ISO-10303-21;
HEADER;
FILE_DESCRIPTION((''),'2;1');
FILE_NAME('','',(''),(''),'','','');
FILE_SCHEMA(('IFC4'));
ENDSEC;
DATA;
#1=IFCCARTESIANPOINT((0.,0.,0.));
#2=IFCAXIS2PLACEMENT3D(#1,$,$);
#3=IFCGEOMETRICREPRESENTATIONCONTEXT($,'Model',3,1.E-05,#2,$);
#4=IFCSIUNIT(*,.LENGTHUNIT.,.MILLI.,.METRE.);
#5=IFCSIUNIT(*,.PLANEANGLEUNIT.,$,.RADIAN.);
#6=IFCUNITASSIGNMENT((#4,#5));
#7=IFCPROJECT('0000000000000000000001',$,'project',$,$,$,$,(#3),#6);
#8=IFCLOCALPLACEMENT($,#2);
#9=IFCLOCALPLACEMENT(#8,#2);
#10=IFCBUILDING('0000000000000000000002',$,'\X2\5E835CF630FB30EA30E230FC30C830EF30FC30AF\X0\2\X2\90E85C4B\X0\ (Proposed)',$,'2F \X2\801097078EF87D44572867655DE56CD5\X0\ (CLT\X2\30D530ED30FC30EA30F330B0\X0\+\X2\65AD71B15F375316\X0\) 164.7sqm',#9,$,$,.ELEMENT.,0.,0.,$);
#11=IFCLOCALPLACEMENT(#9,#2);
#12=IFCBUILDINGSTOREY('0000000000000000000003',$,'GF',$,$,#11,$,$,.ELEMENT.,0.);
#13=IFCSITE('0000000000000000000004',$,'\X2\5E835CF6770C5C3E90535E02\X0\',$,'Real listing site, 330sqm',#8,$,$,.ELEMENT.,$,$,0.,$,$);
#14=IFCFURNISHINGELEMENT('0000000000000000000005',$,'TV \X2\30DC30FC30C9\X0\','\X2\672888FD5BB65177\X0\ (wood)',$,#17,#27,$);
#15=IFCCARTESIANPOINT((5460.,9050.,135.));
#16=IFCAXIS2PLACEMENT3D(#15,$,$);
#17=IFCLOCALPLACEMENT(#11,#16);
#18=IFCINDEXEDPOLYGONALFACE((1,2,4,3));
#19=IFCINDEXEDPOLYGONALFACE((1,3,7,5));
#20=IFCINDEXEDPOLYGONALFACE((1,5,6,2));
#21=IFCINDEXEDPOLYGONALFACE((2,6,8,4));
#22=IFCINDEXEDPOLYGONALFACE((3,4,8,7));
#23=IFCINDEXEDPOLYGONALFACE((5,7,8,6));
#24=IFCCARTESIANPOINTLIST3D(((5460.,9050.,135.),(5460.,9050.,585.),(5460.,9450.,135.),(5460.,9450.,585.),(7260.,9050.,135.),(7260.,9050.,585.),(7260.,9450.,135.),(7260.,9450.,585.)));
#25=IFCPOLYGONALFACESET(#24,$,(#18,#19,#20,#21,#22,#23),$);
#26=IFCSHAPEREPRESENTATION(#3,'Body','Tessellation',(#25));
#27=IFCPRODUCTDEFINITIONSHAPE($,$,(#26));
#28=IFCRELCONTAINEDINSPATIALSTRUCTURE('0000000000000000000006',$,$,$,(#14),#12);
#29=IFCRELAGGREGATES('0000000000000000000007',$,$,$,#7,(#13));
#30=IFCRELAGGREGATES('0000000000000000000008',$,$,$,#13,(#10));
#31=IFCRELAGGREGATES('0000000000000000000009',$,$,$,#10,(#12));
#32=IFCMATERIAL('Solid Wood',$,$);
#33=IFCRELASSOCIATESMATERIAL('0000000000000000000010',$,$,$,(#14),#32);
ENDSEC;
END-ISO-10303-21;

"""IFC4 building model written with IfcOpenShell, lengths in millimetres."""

from ifc_helpers import new_model, si_unit, frame, frame_2d, origin, place, context, project, spatial, rectangle, extrude, material, element, save


model = new_model("IFC4")

# Units and contexts
model_context = context("Model", 3, precision=1e-05, world=origin())
ifc_project = project(units=[si_unit("LENGTHUNIT", "METRE", prefix="MILLI"), si_unit("PLANEANGLEUNIT", "RADIAN")], contexts=[model_context])

# Site, building, storey
site_placement = place(None, origin())
site = spatial("IfcSite", under=ifc_project, at=site_placement, Name="広島県尾道市", ObjectType="Real listing site, 330sqm", CompositionType="ELEMENT", RefElevation=0.0)
building_placement = place(site_placement, origin())
building = spatial("IfcBuilding", under=site, at=building_placement, Name="広島・リモートワーク2部屋 (Proposed)", ObjectType="2F 耐震軸組在来工法 (CLTフローリング+断熱強化) 164.7sqm", CompositionType="ELEMENT", ElevationOfRefHeight=0.0, ElevationOfTerrain=0.0)
storey_placement = place(building_placement, origin())
storey = spatial("IfcBuildingStorey", under=building, at=storey_placement, Name="GF", CompositionType="ELEMENT", Elevation=0.0)

# Shared definitions
ifc_material_1 = material(Name="Solid Wood")

# Furnishing element
furnishing_placement = place(storey_placement, frame((5460.0, 9050.0, 135.0)))
element("IfcFurnishingElement", 1, at=furnishing_placement, inside=storey, material=ifc_material_1, Name="TV ボード", Description="木製家具 (wood)", context=model_context, shape_type="SweptSolid", body=[
    extrude(rectangle(XDim=1800.0, YDim=400.0, at=frame_2d((900.0, 200.0))), frame((5460.0, 9050.0, 135.0)), (0.0, 0.0, 1.0), 450.0),
])

save(model, "model.ifc")
